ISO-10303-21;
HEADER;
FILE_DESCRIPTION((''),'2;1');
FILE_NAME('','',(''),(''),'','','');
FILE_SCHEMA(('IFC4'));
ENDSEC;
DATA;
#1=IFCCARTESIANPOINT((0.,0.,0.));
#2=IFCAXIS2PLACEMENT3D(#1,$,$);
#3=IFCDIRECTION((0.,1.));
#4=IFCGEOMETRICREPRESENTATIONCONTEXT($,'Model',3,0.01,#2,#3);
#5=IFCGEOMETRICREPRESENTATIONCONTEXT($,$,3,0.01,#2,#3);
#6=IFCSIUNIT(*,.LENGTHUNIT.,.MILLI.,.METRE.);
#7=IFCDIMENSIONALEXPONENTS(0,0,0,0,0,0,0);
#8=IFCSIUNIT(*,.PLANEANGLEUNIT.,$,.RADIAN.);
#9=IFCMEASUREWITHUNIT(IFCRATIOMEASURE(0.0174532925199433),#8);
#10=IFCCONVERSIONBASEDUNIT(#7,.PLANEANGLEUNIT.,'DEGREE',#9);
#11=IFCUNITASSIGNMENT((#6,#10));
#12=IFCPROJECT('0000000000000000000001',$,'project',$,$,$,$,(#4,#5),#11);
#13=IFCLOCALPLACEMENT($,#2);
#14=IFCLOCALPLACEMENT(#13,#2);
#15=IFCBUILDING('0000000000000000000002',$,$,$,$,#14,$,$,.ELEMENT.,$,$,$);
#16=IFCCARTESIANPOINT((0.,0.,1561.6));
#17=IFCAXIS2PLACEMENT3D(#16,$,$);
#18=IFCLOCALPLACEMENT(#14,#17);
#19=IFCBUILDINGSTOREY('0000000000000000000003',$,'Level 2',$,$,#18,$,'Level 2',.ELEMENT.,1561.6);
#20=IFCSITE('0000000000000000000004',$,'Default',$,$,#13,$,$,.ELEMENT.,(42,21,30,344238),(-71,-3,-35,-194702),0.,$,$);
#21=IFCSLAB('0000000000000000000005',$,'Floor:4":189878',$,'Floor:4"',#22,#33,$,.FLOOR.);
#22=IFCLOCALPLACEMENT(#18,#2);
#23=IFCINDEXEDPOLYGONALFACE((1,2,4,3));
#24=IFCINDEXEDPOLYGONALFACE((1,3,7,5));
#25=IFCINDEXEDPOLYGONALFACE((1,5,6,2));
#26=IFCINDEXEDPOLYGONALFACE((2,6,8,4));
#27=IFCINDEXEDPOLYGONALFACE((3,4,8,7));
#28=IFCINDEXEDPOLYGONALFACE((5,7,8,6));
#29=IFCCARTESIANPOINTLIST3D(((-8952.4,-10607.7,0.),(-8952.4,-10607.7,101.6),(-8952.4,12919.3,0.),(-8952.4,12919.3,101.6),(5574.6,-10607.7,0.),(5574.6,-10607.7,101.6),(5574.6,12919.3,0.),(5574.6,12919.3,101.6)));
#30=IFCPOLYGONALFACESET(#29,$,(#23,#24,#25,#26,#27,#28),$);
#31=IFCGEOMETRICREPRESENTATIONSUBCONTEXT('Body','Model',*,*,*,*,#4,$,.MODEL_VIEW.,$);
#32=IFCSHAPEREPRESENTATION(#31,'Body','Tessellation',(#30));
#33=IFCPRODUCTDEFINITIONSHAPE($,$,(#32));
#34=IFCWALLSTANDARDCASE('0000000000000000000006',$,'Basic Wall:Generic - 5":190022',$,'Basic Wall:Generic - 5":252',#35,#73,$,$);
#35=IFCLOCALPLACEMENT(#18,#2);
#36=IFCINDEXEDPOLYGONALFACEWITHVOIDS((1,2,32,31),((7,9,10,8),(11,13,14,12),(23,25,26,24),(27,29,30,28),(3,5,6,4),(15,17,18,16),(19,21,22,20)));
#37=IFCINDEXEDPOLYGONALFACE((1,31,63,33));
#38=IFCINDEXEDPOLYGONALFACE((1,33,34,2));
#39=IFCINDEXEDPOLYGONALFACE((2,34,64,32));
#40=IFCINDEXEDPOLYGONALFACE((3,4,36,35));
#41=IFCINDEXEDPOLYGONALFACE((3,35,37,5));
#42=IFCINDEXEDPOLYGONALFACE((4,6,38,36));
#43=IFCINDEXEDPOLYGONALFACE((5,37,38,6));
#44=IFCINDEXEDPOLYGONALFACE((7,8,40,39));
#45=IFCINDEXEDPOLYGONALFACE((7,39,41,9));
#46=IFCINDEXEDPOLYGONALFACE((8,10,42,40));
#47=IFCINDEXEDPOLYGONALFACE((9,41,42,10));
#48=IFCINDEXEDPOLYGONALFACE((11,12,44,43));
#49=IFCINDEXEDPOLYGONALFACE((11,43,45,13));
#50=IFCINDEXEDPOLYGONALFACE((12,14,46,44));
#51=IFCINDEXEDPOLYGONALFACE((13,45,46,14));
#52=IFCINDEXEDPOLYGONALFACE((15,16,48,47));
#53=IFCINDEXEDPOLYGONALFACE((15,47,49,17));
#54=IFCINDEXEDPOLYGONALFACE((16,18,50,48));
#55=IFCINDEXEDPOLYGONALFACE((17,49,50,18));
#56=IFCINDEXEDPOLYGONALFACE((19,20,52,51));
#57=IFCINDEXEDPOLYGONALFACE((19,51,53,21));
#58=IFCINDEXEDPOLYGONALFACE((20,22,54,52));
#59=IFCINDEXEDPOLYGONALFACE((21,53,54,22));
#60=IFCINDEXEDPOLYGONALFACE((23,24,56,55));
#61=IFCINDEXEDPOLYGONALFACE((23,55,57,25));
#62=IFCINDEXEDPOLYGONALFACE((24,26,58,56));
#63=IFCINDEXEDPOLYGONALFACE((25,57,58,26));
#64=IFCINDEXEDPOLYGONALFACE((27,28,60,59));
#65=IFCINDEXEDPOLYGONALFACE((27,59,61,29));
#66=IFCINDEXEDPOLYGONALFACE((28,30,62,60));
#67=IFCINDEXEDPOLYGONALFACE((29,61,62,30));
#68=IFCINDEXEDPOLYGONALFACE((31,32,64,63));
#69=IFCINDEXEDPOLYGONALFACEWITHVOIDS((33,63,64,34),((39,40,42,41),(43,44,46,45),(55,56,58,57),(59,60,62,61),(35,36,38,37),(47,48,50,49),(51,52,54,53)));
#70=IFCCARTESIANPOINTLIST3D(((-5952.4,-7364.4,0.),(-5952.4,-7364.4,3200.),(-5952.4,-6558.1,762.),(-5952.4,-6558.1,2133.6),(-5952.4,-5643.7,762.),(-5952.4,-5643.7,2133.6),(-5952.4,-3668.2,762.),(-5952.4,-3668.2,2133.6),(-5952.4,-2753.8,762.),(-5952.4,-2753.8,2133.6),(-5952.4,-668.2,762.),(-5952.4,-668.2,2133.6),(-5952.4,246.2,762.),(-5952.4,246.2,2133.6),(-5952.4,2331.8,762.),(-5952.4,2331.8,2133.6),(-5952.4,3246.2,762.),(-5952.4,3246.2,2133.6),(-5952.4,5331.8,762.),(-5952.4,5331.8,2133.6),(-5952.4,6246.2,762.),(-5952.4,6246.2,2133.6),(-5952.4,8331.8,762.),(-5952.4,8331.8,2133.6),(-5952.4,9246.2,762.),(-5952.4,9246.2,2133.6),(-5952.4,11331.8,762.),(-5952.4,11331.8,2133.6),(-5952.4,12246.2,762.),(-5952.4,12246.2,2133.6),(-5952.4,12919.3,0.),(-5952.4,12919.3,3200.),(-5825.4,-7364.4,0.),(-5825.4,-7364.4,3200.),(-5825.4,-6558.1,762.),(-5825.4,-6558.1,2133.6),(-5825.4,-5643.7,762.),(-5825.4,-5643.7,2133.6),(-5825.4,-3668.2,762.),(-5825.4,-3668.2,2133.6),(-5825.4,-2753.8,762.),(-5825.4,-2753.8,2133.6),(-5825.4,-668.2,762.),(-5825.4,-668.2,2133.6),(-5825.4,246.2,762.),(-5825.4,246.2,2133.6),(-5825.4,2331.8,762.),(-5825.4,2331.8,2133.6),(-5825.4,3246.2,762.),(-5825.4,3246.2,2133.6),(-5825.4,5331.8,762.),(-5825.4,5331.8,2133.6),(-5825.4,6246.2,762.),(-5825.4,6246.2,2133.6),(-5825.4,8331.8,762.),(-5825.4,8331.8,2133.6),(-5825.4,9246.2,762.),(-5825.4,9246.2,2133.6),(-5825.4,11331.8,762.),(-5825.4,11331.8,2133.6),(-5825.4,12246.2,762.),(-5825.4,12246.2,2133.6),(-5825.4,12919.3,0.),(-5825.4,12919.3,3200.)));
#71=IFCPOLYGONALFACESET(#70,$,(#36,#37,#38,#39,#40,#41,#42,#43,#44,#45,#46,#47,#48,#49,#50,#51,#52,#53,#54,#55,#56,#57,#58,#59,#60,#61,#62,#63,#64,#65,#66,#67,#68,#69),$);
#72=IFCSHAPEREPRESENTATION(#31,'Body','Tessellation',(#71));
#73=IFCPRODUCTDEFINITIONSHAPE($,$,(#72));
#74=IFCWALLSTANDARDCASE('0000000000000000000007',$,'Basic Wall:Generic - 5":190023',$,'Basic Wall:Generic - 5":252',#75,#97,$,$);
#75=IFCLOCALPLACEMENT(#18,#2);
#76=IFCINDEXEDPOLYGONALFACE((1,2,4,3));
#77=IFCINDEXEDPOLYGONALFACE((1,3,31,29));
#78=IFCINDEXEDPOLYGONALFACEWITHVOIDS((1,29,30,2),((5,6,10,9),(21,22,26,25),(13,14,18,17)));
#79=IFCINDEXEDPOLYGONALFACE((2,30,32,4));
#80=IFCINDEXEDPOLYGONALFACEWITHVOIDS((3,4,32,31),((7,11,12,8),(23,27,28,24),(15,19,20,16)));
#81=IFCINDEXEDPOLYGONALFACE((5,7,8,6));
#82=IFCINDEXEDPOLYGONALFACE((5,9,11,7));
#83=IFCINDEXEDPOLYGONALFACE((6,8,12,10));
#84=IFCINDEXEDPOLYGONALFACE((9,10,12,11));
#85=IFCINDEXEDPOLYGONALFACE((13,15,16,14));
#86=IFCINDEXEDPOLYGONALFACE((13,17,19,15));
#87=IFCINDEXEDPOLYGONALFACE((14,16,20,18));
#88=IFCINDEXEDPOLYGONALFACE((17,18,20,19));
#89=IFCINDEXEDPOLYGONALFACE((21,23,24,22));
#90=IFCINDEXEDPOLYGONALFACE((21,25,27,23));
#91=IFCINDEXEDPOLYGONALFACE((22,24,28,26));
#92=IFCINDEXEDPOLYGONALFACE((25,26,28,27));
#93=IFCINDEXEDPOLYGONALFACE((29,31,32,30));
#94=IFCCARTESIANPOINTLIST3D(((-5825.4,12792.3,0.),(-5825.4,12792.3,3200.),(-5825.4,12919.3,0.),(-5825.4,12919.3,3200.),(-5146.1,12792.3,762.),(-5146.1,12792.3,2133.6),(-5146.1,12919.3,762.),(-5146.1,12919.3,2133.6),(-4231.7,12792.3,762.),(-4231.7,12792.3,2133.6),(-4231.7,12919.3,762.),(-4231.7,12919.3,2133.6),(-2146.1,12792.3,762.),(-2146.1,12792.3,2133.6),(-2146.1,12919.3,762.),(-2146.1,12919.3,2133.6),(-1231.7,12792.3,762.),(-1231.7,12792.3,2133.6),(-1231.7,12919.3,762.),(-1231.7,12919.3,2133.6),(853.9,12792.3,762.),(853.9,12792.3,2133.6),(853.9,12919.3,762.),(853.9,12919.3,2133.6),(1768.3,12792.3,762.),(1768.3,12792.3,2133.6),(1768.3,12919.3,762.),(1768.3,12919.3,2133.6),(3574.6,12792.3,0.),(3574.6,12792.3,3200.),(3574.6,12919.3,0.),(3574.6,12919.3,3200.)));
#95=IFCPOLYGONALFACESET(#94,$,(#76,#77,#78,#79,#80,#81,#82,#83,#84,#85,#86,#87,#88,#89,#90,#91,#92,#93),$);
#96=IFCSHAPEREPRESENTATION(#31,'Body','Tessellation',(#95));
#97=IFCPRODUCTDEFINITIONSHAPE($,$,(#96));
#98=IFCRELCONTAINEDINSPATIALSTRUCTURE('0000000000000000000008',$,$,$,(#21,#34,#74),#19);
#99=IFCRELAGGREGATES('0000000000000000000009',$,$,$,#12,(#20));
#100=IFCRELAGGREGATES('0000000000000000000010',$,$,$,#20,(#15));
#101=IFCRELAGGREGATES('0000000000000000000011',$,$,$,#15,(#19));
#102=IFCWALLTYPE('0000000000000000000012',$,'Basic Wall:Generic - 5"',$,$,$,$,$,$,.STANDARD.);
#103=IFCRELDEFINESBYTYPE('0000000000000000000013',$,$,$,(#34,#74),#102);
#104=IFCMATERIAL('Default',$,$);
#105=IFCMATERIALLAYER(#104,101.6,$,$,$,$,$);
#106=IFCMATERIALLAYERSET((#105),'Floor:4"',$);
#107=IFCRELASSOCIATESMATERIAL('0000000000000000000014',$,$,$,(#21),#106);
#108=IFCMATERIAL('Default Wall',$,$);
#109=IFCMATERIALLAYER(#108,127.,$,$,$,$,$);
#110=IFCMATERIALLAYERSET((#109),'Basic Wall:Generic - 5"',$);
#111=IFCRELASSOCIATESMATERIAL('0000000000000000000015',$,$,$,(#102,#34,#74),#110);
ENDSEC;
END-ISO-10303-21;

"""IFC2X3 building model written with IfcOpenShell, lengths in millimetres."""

from ifc_helpers import new_model, entity, si_unit, converted_unit, direction, frame, frame_2d, origin, place, context, subcontext, project, spatial, polyline, rectangle, extrude, clip, bounded_halfspace, material, layer, layer_set, layer_usage, type_object, element, save


model = new_model("IFC2X3")

# Units and contexts
model_context = context("Model", 3, precision=0.01, world=origin(), true_north=direction((0.0, 1.0)))
context_of_model = context(None, 3, precision=0.01, world=origin(), true_north=direction((0.0, 1.0)))
body_context = subcontext(model_context, "Body", "Model", "MODEL_VIEW")
ifc_project = project(units=[si_unit("LENGTHUNIT", "METRE", prefix="MILLI"), converted_unit("PLANEANGLEUNIT", "DEGREE", entity("IfcRatioMeasure", 0.0174532925199433), si_unit("PLANEANGLEUNIT", "RADIAN"), dimensions=[0, 0, 0, 0, 0, 0, 0])], contexts=[model_context, context_of_model])

# Site, building, storey
site_placement = place(None, origin())
site = spatial("IfcSite", under=ifc_project, at=site_placement, Name="Default", CompositionType="ELEMENT", RefLatitude=(42, 21, 30, 344238), RefLongitude=(-71, -3, -35, -194702), RefElevation=0.0)
building_placement = place(site_placement, origin())
building = spatial("IfcBuilding", under=site, at=building_placement, CompositionType="ELEMENT")
storey_placement = place(building_placement, frame((0.0, 0.0, 1561.6)))
storey = spatial("IfcBuildingStorey", under=building, at=storey_placement, Name="Level 2", LongName="Level 2", CompositionType="ELEMENT", Elevation=1561.6)

# Slab
ifc_material_1 = material(Name="Default")
ifc_layer_1 = layer(ifc_material_1, 101.6)
ifc_layer_set_1 = layer_set([ifc_layer_1], Name="Floor:4\"")
ifc_layer_usage_1 = layer_usage(ifc_layer_set_1, "AXIS3", "POSITIVE", 0.0)
slab_placement = place(storey_placement, origin())
element("IfcSlab", 1, at=slab_placement, inside=storey, material=ifc_layer_usage_1, Name="Floor:4\":189878", ObjectType="Floor:4\"", PredefinedType="FLOOR", context=body_context, shape_type="SweptSolid", body=[
    extrude(rectangle(XDim=23527.0, YDim=14527.0, at=frame_2d((0.0, 0.0), x_axis=(1.0, 0.0))), frame((-1688.9, 1155.8, 101.6), z_axis=(0.0, 0.0, -1.0), x_axis=(0.0, 1.0, 0.0)), (0.0, 0.0, 1.0), 101.6),
])

# Walls, openings
ifc_material_2 = material(Name="Default Wall")
ifc_layer_2 = layer(ifc_material_2, 127.0)
ifc_layer_set_2 = layer_set([ifc_layer_2], Name="Basic Wall:Generic - 5\"")
ifc_layer_usage_2 = layer_usage(ifc_layer_set_2, "AXIS2", "NEGATIVE", 63.5)
wall_type = type_object("IfcWallType", Name="Basic Wall:Generic - 5\"", PredefinedType="STANDARD", material=ifc_layer_set_2)
wall_1_placement = place(storey_placement, frame((-5888.9, -7364.4, 0.0), z_axis=(0.0, 0.0, 1.0), x_axis=(0.0, 1.0, 0.0)))
wall_1 = element("IfcWallStandardCase", 2, at=wall_1_placement, inside=storey, type_object=wall_type, material=ifc_layer_usage_2, Name="Basic Wall:Generic - 5\":190022", ObjectType="Basic Wall:Generic - 5\":252", context=body_context, shape_type="Clipping", body=[
    clip(extrude(rectangle(XDim=20283.7, YDim=127.0, at=frame_2d((10141.9, 0.0), x_axis=(-1.0, 0.0))), origin(), (0.0, 0.0, 1.0), 3200.0), bounded_halfspace(frame((0.0, -63.5, 3200.0), z_axis=(0.0, 0.0, -1.0), x_axis=(0.0, -1.0, 0.0)), True, frame((0.0, -63.5, 3200.0)), polyline([(0.0, 0.0), (127.0, 0.0), (20156.7, 0.0), (20283.7, 0.0), (20283.7, 127.0), (0.0, 127.0), (0.0, 0.0)]))),
])
opening_1_placement = place(wall_1_placement, frame((18696.2, -63.5, 762.0)))
element("IfcOpeningElement", 3, at=opening_1_placement, cuts=wall_1, ObjectType="Opening", context=body_context, shape_type="SweptSolid", body=[
    extrude(rectangle(XDim=1371.6, YDim=914.4, at=frame_2d((685.8, 457.2), x_axis=(-1.0, 0.0))), frame((0.0, 0.0, 0.0), z_axis=(0.0, 1.0, 0.0), x_axis=(0.0, 0.0, 1.0)), (0.0, 0.0, 1.0), 127.0),
])
opening_2_placement = place(wall_1_placement, frame((15696.2, -63.5, 762.0)))
element("IfcOpeningElement", 4, at=opening_2_placement, cuts=wall_1, ObjectType="Opening", context=body_context, shape_type="SweptSolid", body=[
    extrude(rectangle(XDim=1371.6, YDim=914.4, at=frame_2d((685.8, 457.2), x_axis=(-1.0, 0.0))), frame((0.0, 0.0, 0.0), z_axis=(0.0, 1.0, 0.0), x_axis=(0.0, 0.0, 1.0)), (0.0, 0.0, 1.0), 127.0),
])
opening_3_placement = place(wall_1_placement, frame((12696.2, -63.5, 762.0)))
element("IfcOpeningElement", 5, at=opening_3_placement, cuts=wall_1, ObjectType="Opening", context=body_context, shape_type="SweptSolid", body=[
    extrude(rectangle(XDim=1371.6, YDim=914.4, at=frame_2d((685.8, 457.2), x_axis=(-1.0, 0.0))), frame((0.0, 0.0, 0.0), z_axis=(0.0, 1.0, 0.0), x_axis=(0.0, 0.0, 1.0)), (0.0, 0.0, 1.0), 127.0),
])
opening_4_placement = place(wall_1_placement, frame((9696.2, -63.5, 762.0)))
element("IfcOpeningElement", 6, at=opening_4_placement, cuts=wall_1, ObjectType="Opening", context=body_context, shape_type="SweptSolid", body=[
    extrude(rectangle(XDim=1371.6, YDim=914.4, at=frame_2d((685.8, 457.2), x_axis=(-1.0, 0.0))), frame((0.0, 0.0, 0.0), z_axis=(0.0, 1.0, 0.0), x_axis=(0.0, 0.0, 1.0)), (0.0, 0.0, 1.0), 127.0),
])
opening_5_placement = place(wall_1_placement, frame((6696.2, -63.5, 762.0)))
element("IfcOpeningElement", 7, at=opening_5_placement, cuts=wall_1, ObjectType="Opening", context=body_context, shape_type="SweptSolid", body=[
    extrude(rectangle(XDim=1371.6, YDim=914.4, at=frame_2d((685.8, 457.2), x_axis=(-1.0, 0.0))), frame((0.0, 0.0, 0.0), z_axis=(0.0, 1.0, 0.0), x_axis=(0.0, 0.0, 1.0)), (0.0, 0.0, 1.0), 127.0),
])
opening_6_placement = place(wall_1_placement, frame((3696.2, -63.5, 762.0)))
element("IfcOpeningElement", 8, at=opening_6_placement, cuts=wall_1, ObjectType="Opening", context=body_context, shape_type="SweptSolid", body=[
    extrude(rectangle(XDim=1371.6, YDim=914.4, at=frame_2d((685.8, 457.2), x_axis=(-1.0, 0.0))), frame((0.0, 0.0, 0.0), z_axis=(0.0, 1.0, 0.0), x_axis=(0.0, 0.0, 1.0)), (0.0, 0.0, 1.0), 127.0),
])
opening_7_placement = place(wall_1_placement, frame((806.3, -63.5, 762.0)))
element("IfcOpeningElement", 9, at=opening_7_placement, cuts=wall_1, ObjectType="Opening", context=body_context, shape_type="SweptSolid", body=[
    extrude(rectangle(XDim=1371.6, YDim=914.4, at=frame_2d((685.8, 457.2), x_axis=(-1.0, 0.0))), frame((0.0, 0.0, 0.0), z_axis=(0.0, 1.0, 0.0), x_axis=(0.0, 0.0, 1.0)), (0.0, 0.0, 1.0), 127.0),
])
ifc_layer_usage_3 = layer_usage(ifc_layer_set_2, "AXIS2", "NEGATIVE", 63.5)
wall_2_placement = place(storey_placement, frame((-5825.4, 12855.8, 0.0)))
wall_2 = element("IfcWallStandardCase", 10, at=wall_2_placement, inside=storey, type_object=wall_type, material=ifc_layer_usage_3, Name="Basic Wall:Generic - 5\":190023", ObjectType="Basic Wall:Generic - 5\":252", context=body_context, shape_type="Clipping", body=[
    clip(extrude(rectangle(XDim=9400.0, YDim=127.0, at=frame_2d((4700.0, 0.0), x_axis=(-1.0, 0.0))), origin(), (0.0, 0.0, 1.0), 3200.0), bounded_halfspace(frame((0.0, -63.5, 3200.0), z_axis=(0.0, 0.0, -1.0), x_axis=(1.0, 0.0, 0.0)), True, frame((0.0, -63.5, 3200.0)), polyline([(0.0, 0.0), (9273.0, 0.0), (9400.0, 0.0), (9400.0, 127.0), (0.0, 127.0), (0.0, 0.0)]))),
])
opening_8_placement = place(wall_2_placement, frame((7593.7, 63.5, 762.0)))
element("IfcOpeningElement", 11, at=opening_8_placement, cuts=wall_2, ObjectType="Opening", context=body_context, shape_type="SweptSolid", body=[
    extrude(rectangle(XDim=1371.6, YDim=914.4, at=frame_2d((685.8, 457.2), x_axis=(-1.0, 0.0))), frame((0.0, 0.0, 0.0), z_axis=(0.0, -1.0, 0.0), x_axis=(0.0, 0.0, 1.0)), (0.0, 0.0, 1.0), 127.0),
])
opening_9_placement = place(wall_2_placement, frame((4593.7, 63.5, 762.0)))
element("IfcOpeningElement", 12, at=opening_9_placement, cuts=wall_2, ObjectType="Opening", context=body_context, shape_type="SweptSolid", body=[
    extrude(rectangle(XDim=1371.6, YDim=914.4, at=frame_2d((685.8, 457.2), x_axis=(-1.0, 0.0))), frame((0.0, 0.0, 0.0), z_axis=(0.0, -1.0, 0.0), x_axis=(0.0, 0.0, 1.0)), (0.0, 0.0, 1.0), 127.0),
])
opening_10_placement = place(wall_2_placement, frame((1593.7, 63.5, 762.0)))
element("IfcOpeningElement", 13, at=opening_10_placement, cuts=wall_2, ObjectType="Opening", context=body_context, shape_type="SweptSolid", body=[
    extrude(rectangle(XDim=1371.6, YDim=914.4, at=frame_2d((685.8, 457.2), x_axis=(-1.0, 0.0))), frame((0.0, 0.0, 0.0), z_axis=(0.0, -1.0, 0.0), x_axis=(0.0, 0.0, 1.0)), (0.0, 0.0, 1.0), 127.0),
])

save(model, "model.ifc")
